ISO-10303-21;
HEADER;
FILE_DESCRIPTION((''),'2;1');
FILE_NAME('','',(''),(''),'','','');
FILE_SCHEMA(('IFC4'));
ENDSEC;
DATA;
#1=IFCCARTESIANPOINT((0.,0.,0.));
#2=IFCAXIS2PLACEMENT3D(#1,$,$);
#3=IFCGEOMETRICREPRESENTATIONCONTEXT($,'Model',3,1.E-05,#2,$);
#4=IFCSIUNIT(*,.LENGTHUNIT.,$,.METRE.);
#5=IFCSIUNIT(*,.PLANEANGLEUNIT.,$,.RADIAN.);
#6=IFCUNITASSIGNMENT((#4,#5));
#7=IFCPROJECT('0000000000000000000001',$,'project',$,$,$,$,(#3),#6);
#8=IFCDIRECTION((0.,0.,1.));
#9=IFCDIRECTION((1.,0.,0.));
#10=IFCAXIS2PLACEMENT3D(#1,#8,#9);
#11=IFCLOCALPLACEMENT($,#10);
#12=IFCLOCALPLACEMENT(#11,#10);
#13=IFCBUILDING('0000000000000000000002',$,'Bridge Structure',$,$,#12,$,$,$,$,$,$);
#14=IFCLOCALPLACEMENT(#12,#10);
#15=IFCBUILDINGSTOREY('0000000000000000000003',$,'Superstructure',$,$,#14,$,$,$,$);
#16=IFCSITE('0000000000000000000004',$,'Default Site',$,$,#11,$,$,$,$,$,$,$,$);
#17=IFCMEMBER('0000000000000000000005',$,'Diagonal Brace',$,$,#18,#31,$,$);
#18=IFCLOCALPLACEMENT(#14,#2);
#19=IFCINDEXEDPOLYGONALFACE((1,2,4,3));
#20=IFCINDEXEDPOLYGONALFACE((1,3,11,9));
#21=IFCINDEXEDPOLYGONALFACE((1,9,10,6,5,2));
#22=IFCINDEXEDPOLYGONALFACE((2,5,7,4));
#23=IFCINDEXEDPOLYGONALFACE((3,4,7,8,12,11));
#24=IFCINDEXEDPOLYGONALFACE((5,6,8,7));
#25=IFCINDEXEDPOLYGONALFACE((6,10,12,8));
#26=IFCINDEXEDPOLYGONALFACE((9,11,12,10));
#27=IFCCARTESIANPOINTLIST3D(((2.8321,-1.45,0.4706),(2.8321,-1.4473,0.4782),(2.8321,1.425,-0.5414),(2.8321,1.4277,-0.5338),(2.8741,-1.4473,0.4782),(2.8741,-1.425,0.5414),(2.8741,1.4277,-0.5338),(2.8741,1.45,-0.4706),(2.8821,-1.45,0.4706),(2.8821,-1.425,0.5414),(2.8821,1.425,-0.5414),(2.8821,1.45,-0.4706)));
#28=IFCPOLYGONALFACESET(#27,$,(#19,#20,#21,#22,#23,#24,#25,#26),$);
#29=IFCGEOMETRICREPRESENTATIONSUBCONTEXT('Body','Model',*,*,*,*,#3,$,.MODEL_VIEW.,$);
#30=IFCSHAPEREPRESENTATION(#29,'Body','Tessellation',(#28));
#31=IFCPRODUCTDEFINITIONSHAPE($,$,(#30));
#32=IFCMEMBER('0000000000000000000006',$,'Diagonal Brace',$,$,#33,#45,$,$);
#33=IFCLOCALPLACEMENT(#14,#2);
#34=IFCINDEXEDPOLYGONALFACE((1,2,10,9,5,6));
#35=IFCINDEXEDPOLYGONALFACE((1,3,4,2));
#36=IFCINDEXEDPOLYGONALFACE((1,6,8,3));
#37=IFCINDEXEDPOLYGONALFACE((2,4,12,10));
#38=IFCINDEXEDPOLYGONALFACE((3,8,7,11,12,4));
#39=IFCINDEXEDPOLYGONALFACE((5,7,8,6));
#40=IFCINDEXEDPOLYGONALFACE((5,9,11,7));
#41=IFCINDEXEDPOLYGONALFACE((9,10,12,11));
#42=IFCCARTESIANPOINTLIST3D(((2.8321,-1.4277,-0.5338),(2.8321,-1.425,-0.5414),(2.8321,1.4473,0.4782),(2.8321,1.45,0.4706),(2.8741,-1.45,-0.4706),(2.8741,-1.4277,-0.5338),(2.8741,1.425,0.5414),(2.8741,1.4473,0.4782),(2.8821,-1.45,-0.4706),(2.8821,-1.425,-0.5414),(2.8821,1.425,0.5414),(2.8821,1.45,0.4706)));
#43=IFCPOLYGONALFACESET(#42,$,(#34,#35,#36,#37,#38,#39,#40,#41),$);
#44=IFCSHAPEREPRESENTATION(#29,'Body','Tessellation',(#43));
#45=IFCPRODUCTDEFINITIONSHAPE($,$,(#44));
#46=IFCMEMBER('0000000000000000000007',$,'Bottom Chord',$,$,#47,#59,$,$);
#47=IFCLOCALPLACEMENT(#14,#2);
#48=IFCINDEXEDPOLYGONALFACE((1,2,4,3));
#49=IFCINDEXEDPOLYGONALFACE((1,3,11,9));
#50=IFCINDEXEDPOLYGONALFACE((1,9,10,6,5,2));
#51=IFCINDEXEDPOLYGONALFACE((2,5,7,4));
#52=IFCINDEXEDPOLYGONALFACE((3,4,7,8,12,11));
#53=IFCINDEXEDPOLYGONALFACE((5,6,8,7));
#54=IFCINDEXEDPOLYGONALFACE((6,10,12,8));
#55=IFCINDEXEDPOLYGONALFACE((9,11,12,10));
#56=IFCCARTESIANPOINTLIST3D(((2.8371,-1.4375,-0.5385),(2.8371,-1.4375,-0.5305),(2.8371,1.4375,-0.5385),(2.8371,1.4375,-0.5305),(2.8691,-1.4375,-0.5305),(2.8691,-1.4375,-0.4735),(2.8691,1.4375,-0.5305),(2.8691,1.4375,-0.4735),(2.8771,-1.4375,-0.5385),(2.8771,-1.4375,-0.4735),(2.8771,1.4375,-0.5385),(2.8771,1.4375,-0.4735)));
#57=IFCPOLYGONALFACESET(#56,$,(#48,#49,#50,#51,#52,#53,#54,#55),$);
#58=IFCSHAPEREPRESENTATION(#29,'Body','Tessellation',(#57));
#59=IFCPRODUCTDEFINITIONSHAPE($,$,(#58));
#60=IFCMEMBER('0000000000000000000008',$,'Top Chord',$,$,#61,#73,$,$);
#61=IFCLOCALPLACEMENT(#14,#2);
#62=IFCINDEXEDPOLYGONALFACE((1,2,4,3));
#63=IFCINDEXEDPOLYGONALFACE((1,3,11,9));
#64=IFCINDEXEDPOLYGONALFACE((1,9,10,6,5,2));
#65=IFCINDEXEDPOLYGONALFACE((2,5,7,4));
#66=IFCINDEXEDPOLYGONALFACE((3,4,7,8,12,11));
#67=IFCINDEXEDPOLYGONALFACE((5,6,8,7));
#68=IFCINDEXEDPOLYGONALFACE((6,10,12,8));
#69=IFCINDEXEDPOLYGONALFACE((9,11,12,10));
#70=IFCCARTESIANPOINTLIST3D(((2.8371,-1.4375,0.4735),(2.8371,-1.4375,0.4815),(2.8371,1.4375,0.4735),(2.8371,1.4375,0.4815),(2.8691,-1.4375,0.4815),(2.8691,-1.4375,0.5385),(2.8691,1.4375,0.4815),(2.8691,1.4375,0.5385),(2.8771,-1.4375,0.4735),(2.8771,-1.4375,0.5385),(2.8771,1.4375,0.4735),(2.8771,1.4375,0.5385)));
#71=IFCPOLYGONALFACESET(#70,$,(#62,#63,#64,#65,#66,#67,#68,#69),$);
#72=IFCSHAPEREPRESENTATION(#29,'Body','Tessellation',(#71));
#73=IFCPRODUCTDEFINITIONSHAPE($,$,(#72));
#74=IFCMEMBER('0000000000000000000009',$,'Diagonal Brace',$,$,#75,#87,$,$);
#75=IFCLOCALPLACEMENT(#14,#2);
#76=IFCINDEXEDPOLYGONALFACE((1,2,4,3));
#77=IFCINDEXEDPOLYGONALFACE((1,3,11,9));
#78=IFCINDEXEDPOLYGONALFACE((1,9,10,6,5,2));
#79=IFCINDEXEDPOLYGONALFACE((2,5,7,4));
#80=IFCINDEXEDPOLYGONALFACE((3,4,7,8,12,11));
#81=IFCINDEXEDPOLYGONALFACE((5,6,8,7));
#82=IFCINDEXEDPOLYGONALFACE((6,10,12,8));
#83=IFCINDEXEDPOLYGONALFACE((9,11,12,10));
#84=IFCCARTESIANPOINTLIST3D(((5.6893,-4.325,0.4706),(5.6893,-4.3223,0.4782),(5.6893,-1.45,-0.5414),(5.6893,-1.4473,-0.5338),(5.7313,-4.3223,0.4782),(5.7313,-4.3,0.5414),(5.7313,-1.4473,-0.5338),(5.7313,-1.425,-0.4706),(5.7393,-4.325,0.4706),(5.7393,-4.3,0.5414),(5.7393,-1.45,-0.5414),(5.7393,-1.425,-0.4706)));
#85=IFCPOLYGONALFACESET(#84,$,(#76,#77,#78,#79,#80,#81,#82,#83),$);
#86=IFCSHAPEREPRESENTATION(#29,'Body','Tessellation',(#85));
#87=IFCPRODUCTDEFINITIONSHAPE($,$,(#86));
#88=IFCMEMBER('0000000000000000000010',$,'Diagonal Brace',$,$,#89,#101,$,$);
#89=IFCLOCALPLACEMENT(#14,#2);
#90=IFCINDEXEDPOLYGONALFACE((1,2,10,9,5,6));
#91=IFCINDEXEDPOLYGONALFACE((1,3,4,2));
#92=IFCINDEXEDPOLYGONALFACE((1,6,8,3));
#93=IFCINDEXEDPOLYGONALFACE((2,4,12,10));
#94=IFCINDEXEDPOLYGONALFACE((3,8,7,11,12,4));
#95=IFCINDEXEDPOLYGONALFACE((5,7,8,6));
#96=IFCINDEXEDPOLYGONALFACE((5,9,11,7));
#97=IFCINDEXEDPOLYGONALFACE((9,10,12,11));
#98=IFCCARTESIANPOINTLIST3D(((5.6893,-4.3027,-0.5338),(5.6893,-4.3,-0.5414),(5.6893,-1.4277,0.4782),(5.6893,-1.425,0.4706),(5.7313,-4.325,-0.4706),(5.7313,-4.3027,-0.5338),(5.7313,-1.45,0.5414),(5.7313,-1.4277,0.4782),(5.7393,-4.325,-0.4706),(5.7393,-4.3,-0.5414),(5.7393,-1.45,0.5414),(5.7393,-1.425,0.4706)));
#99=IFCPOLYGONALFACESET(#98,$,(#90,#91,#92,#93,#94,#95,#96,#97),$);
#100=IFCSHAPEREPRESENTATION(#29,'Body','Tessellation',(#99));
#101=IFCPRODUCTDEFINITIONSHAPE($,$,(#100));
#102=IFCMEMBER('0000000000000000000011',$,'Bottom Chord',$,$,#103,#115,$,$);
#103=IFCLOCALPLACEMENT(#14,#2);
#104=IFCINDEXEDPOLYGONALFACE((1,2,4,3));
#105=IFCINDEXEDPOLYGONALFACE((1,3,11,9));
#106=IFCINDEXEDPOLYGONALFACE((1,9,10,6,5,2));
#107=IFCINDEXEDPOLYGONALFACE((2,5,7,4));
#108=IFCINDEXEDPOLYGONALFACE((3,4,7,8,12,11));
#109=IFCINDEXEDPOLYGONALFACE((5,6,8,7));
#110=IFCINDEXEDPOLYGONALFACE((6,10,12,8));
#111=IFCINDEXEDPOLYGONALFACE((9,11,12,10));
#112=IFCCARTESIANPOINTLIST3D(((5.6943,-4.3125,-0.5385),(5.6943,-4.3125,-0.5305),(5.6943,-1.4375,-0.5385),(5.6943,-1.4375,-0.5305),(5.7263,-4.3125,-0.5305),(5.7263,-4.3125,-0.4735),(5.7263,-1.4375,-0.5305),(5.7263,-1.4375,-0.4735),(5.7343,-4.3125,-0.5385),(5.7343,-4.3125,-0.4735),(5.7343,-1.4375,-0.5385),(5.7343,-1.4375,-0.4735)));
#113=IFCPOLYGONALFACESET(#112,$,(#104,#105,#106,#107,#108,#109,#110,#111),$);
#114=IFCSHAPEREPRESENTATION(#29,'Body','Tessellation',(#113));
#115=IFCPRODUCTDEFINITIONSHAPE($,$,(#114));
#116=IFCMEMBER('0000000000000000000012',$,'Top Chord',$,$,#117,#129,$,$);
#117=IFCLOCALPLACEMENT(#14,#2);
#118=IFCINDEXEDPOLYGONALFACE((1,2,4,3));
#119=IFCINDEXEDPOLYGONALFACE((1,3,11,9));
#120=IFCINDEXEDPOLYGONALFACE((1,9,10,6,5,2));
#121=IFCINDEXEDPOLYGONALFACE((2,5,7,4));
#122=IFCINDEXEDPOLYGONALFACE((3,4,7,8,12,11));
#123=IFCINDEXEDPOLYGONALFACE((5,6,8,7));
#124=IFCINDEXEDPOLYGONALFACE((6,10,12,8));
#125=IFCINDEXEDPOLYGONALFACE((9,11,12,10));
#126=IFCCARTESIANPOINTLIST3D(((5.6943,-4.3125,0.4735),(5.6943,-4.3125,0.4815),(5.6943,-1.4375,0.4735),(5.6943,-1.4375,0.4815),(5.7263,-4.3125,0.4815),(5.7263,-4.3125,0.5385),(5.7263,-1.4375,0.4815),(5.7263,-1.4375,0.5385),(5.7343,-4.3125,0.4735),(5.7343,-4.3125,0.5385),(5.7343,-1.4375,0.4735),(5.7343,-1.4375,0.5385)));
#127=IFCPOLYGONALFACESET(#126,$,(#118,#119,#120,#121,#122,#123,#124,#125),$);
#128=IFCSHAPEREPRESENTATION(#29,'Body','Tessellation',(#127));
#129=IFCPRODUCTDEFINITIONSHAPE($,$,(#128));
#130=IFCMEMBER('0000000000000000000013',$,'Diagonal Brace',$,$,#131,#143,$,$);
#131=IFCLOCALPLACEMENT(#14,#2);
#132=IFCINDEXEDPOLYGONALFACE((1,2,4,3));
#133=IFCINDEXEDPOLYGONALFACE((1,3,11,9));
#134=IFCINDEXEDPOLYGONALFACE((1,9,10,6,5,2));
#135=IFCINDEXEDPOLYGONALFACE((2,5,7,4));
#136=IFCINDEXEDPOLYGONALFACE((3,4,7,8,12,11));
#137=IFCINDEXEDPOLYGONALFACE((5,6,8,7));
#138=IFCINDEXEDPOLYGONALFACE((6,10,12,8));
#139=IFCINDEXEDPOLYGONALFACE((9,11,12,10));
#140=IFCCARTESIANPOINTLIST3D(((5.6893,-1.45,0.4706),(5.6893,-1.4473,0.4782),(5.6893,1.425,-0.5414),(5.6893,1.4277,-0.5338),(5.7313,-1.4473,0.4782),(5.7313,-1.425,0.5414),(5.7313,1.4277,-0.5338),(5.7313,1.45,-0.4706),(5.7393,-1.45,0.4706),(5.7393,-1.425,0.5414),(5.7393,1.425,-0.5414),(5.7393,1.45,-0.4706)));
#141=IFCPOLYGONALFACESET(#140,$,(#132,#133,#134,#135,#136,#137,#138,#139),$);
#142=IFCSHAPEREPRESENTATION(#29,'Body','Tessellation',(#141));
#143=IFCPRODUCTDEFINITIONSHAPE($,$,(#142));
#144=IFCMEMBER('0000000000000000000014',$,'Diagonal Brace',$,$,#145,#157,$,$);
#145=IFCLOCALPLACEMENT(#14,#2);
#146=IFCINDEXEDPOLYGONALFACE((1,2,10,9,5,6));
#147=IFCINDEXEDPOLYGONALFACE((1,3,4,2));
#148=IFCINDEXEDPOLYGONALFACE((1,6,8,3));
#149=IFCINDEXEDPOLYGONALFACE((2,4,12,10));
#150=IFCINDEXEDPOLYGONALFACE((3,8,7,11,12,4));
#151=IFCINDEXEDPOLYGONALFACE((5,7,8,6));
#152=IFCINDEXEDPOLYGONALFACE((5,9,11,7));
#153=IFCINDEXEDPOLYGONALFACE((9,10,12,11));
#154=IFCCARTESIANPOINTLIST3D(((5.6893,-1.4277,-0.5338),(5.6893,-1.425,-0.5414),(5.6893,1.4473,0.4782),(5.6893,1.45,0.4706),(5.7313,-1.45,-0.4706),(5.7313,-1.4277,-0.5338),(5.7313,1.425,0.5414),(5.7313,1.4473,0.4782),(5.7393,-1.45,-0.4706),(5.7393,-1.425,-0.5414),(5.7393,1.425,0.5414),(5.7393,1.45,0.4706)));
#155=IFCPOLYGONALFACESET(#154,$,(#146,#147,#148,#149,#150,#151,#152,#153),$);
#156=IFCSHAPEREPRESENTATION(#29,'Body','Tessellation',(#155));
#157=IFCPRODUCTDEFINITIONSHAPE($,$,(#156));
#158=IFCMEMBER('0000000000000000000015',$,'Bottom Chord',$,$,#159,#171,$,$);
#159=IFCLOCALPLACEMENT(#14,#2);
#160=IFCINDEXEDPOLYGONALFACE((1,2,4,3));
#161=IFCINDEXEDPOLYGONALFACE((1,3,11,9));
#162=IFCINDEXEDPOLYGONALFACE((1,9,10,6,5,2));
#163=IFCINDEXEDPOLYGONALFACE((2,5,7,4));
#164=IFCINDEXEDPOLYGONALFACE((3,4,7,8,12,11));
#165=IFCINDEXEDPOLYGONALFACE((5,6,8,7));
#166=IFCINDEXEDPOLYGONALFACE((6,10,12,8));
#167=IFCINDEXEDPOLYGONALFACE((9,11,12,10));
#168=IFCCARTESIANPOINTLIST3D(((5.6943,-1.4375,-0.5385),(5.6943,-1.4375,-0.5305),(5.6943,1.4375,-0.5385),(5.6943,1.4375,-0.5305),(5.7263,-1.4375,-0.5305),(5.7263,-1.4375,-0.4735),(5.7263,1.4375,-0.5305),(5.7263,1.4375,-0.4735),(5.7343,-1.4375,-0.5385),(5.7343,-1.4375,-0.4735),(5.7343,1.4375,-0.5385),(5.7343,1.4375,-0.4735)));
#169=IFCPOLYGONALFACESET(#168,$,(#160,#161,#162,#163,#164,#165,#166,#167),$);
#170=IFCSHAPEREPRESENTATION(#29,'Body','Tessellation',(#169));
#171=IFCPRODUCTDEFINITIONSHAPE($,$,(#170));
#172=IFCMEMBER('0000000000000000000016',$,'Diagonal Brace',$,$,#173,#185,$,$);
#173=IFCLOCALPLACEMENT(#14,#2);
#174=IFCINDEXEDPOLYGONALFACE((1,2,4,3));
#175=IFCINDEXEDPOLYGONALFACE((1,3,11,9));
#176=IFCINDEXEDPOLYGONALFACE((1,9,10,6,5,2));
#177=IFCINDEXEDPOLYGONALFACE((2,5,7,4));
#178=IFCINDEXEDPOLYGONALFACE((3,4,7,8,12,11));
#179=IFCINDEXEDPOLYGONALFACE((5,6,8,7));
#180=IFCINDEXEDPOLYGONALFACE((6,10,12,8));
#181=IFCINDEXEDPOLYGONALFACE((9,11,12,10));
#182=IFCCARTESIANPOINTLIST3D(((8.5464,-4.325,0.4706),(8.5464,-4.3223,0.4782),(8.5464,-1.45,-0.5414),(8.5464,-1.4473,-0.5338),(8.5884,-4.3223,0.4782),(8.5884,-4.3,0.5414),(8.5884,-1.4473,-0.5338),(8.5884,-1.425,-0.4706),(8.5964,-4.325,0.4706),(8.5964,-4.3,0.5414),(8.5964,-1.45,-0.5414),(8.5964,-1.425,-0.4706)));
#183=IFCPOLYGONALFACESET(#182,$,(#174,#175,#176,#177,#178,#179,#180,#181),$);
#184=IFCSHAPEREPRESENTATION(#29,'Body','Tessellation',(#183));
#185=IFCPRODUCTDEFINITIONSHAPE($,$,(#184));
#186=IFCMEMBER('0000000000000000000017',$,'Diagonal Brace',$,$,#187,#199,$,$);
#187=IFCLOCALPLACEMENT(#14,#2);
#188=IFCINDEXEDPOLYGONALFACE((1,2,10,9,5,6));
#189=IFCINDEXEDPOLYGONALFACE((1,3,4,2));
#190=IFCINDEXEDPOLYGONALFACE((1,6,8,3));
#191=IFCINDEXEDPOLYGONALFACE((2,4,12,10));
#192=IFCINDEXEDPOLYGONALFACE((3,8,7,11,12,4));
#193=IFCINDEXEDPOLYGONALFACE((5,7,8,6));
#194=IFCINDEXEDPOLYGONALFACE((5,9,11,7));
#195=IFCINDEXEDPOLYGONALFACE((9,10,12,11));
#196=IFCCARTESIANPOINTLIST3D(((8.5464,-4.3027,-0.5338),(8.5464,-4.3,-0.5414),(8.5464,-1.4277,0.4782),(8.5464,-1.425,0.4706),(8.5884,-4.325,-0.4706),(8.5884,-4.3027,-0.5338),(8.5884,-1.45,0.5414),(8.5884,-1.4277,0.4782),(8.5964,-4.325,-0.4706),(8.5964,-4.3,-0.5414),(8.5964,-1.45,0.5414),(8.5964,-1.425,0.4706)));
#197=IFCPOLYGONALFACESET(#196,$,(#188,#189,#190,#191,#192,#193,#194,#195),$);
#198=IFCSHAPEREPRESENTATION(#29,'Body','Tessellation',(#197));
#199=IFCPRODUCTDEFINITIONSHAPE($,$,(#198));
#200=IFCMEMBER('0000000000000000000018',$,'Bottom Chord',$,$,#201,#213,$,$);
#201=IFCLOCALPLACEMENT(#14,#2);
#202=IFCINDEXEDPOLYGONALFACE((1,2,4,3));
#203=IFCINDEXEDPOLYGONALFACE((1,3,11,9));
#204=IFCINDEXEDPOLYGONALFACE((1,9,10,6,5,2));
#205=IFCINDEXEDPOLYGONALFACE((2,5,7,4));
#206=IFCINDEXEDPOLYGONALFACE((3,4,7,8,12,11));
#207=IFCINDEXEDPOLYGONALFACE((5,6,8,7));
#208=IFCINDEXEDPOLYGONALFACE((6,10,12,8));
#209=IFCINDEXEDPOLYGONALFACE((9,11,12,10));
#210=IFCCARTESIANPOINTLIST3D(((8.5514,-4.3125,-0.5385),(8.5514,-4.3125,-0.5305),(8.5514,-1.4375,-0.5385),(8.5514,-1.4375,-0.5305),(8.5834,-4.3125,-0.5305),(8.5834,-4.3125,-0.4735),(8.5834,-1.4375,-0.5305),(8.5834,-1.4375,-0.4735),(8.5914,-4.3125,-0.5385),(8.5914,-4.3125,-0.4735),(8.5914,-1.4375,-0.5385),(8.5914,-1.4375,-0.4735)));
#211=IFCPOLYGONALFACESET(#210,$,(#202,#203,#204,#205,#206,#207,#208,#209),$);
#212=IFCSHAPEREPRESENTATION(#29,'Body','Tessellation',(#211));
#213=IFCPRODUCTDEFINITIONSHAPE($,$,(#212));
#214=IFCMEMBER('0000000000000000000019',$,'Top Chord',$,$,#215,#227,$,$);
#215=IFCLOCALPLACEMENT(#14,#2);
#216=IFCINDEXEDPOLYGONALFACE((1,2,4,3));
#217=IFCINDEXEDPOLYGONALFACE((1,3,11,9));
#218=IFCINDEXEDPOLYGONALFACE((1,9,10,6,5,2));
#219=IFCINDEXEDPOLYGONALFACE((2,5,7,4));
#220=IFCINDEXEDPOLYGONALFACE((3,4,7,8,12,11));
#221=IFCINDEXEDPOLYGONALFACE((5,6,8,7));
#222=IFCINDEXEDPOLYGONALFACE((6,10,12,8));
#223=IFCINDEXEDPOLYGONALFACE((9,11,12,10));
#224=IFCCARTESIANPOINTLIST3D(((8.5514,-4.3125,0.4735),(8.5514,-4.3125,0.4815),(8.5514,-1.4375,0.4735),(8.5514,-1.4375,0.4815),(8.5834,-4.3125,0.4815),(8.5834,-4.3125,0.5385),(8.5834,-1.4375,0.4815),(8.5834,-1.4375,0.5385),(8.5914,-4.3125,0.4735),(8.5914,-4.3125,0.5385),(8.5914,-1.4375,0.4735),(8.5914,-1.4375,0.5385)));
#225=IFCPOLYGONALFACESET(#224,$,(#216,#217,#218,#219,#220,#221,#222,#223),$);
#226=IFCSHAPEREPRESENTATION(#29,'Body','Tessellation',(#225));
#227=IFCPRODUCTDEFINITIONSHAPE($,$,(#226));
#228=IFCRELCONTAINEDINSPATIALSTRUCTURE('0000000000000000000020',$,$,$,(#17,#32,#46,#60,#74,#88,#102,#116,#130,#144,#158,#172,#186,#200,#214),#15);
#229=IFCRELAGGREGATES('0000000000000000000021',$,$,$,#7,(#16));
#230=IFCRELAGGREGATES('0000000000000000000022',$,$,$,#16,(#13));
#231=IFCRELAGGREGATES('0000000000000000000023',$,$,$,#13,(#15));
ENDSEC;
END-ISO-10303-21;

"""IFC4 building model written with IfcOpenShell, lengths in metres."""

from ifc_helpers import new_model, si_unit, frame, origin, origin_with_axes, origin_2d_with_axis, place, context, subcontext, project, spatial, l_section, extrude, element, save


model = new_model("IFC4")

# Units and contexts
model_context = context("Model", 3, precision=1e-05, world=origin())
body_context = subcontext(model_context, "Body", "Model", "MODEL_VIEW")
ifc_project = project(units=[si_unit("LENGTHUNIT", "METRE"), si_unit("PLANEANGLEUNIT", "RADIAN")], contexts=[model_context])

# Site, building, storey
site_placement = place(None, origin_with_axes())
site = spatial("IfcSite", under=ifc_project, at=site_placement, Name="Default Site")
building_placement = place(site_placement, origin_with_axes())
building = spatial("IfcBuilding", under=site, at=building_placement, Name="Bridge Structure")
storey_placement = place(building_placement, origin_with_axes())
storey = spatial("IfcBuildingStorey", under=building, at=storey_placement, Name="Superstructure")

# Members
for number, where, z_axis, x_axis, name in (
    (1, (2.8571, -1.4375, 0.506), (0.0, 0.943269, -0.332031), (-1.0, 0.0, 0.0), "Diagonal Brace"),
    (2, (2.8571, -1.4375, -0.506), (0.0, 0.943269, 0.332031), (-1.0, 0.0, 0.0), "Diagonal Brace"),
):
    element("IfcMember", number, at=place(storey_placement, frame(where, z_axis=z_axis, x_axis=x_axis)), inside=storey, Name=name, context=body_context, shape_type="SweptSolid", body=[
        extrude(l_section(Depth=0.075, Width=0.05, Thickness=0.008, at=origin_2d_with_axis()), origin_with_axes(), (0.0, 0.0, 1.0), 3.0479),
    ])
for number, where, z_axis, x_axis, name in (
    (3, (2.8571, -1.4375, -0.506), (0.0, 1.0, 0.0), (-1.0, 0.0, 0.0), "Bottom Chord"),
    (4, (2.8571, -1.4375, 0.506), (0.0, 1.0, 0.0), (-1.0, 0.0, 0.0), "Top Chord"),
):
    element("IfcMember", number, at=place(storey_placement, frame(where, z_axis=z_axis, x_axis=x_axis)), inside=storey, Name=name, context=body_context, shape_type="SweptSolid", body=[
        extrude(l_section(Depth=0.065, Width=0.04, Thickness=0.008, at=origin_2d_with_axis()), origin_with_axes(), (0.0, 0.0, 1.0), 2.875),
    ])
for number, where, z_axis, x_axis, name in (
    (5, (5.7143, -4.3125, 0.506), (0.0, 0.943269, -0.332031), (-1.0, 0.0, 0.0), "Diagonal Brace"),
    (6, (5.7143, -4.3125, -0.506), (0.0, 0.943269, 0.332031), (-1.0, 0.0, 0.0), "Diagonal Brace"),
):
    element("IfcMember", number, at=place(storey_placement, frame(where, z_axis=z_axis, x_axis=x_axis)), inside=storey, Name=name, context=body_context, shape_type="SweptSolid", body=[
        extrude(l_section(Depth=0.075, Width=0.05, Thickness=0.008, at=origin_2d_with_axis()), origin_with_axes(), (0.0, 0.0, 1.0), 3.0479),
    ])
for number, where, z_axis, x_axis, name in (
    (7, (5.7143, -4.3125, -0.506), (0.0, 1.0, 0.0), (-1.0, 0.0, 0.0), "Bottom Chord"),
    (8, (5.7143, -4.3125, 0.506), (0.0, 1.0, 0.0), (-1.0, 0.0, 0.0), "Top Chord"),
):
    element("IfcMember", number, at=place(storey_placement, frame(where, z_axis=z_axis, x_axis=x_axis)), inside=storey, Name=name, context=body_context, shape_type="SweptSolid", body=[
        extrude(l_section(Depth=0.065, Width=0.04, Thickness=0.008, at=origin_2d_with_axis()), origin_with_axes(), (0.0, 0.0, 1.0), 2.875),
    ])
for number, where, z_axis, x_axis, name in (
    (9, (5.7143, -1.4375, 0.506), (0.0, 0.943269, -0.332031), (-1.0, 0.0, 0.0), "Diagonal Brace"),
    (10, (5.7143, -1.4375, -0.506), (0.0, 0.943269, 0.332031), (-1.0, 0.0, 0.0), "Diagonal Brace"),
):
    element("IfcMember", number, at=place(storey_placement, frame(where, z_axis=z_axis, x_axis=x_axis)), inside=storey, Name=name, context=body_context, shape_type="SweptSolid", body=[
        extrude(l_section(Depth=0.075, Width=0.05, Thickness=0.008, at=origin_2d_with_axis()), origin_with_axes(), (0.0, 0.0, 1.0), 3.0479),
    ])
member_placement = place(storey_placement, frame((5.7143, -1.4375, -0.506), z_axis=(0.0, 1.0, 0.0), x_axis=(-1.0, 0.0, 0.0)))
element("IfcMember", 11, at=member_placement, inside=storey, Name="Bottom Chord", context=body_context, shape_type="SweptSolid", body=[
    extrude(l_section(Depth=0.065, Width=0.04, Thickness=0.008, at=origin_2d_with_axis()), origin_with_axes(), (0.0, 0.0, 1.0), 2.875),
])
for number, where, z_axis, x_axis, name in (
    (12, (8.5714, -4.3125, 0.506), (0.0, 0.943269, -0.332031), (-1.0, 0.0, 0.0), "Diagonal Brace"),
    (13, (8.5714, -4.3125, -0.506), (0.0, 0.943269, 0.332031), (-1.0, 0.0, 0.0), "Diagonal Brace"),
):
    element("IfcMember", number, at=place(storey_placement, frame(where, z_axis=z_axis, x_axis=x_axis)), inside=storey, Name=name, context=body_context, shape_type="SweptSolid", body=[
        extrude(l_section(Depth=0.075, Width=0.05, Thickness=0.008, at=origin_2d_with_axis()), origin_with_axes(), (0.0, 0.0, 1.0), 3.0479),
    ])
for number, where, z_axis, x_axis, name in (
    (14, (8.5714, -4.3125, -0.506), (0.0, 1.0, 0.0), (-1.0, 0.0, 0.0), "Bottom Chord"),
    (15, (8.5714, -4.3125, 0.506), (0.0, 1.0, 0.0), (-1.0, 0.0, 0.0), "Top Chord"),
):
    element("IfcMember", number, at=place(storey_placement, frame(where, z_axis=z_axis, x_axis=x_axis)), inside=storey, Name=name, context=body_context, shape_type="SweptSolid", body=[
        extrude(l_section(Depth=0.065, Width=0.04, Thickness=0.008, at=origin_2d_with_axis()), origin_with_axes(), (0.0, 0.0, 1.0), 2.875),
    ])

save(model, "model.ifc")
